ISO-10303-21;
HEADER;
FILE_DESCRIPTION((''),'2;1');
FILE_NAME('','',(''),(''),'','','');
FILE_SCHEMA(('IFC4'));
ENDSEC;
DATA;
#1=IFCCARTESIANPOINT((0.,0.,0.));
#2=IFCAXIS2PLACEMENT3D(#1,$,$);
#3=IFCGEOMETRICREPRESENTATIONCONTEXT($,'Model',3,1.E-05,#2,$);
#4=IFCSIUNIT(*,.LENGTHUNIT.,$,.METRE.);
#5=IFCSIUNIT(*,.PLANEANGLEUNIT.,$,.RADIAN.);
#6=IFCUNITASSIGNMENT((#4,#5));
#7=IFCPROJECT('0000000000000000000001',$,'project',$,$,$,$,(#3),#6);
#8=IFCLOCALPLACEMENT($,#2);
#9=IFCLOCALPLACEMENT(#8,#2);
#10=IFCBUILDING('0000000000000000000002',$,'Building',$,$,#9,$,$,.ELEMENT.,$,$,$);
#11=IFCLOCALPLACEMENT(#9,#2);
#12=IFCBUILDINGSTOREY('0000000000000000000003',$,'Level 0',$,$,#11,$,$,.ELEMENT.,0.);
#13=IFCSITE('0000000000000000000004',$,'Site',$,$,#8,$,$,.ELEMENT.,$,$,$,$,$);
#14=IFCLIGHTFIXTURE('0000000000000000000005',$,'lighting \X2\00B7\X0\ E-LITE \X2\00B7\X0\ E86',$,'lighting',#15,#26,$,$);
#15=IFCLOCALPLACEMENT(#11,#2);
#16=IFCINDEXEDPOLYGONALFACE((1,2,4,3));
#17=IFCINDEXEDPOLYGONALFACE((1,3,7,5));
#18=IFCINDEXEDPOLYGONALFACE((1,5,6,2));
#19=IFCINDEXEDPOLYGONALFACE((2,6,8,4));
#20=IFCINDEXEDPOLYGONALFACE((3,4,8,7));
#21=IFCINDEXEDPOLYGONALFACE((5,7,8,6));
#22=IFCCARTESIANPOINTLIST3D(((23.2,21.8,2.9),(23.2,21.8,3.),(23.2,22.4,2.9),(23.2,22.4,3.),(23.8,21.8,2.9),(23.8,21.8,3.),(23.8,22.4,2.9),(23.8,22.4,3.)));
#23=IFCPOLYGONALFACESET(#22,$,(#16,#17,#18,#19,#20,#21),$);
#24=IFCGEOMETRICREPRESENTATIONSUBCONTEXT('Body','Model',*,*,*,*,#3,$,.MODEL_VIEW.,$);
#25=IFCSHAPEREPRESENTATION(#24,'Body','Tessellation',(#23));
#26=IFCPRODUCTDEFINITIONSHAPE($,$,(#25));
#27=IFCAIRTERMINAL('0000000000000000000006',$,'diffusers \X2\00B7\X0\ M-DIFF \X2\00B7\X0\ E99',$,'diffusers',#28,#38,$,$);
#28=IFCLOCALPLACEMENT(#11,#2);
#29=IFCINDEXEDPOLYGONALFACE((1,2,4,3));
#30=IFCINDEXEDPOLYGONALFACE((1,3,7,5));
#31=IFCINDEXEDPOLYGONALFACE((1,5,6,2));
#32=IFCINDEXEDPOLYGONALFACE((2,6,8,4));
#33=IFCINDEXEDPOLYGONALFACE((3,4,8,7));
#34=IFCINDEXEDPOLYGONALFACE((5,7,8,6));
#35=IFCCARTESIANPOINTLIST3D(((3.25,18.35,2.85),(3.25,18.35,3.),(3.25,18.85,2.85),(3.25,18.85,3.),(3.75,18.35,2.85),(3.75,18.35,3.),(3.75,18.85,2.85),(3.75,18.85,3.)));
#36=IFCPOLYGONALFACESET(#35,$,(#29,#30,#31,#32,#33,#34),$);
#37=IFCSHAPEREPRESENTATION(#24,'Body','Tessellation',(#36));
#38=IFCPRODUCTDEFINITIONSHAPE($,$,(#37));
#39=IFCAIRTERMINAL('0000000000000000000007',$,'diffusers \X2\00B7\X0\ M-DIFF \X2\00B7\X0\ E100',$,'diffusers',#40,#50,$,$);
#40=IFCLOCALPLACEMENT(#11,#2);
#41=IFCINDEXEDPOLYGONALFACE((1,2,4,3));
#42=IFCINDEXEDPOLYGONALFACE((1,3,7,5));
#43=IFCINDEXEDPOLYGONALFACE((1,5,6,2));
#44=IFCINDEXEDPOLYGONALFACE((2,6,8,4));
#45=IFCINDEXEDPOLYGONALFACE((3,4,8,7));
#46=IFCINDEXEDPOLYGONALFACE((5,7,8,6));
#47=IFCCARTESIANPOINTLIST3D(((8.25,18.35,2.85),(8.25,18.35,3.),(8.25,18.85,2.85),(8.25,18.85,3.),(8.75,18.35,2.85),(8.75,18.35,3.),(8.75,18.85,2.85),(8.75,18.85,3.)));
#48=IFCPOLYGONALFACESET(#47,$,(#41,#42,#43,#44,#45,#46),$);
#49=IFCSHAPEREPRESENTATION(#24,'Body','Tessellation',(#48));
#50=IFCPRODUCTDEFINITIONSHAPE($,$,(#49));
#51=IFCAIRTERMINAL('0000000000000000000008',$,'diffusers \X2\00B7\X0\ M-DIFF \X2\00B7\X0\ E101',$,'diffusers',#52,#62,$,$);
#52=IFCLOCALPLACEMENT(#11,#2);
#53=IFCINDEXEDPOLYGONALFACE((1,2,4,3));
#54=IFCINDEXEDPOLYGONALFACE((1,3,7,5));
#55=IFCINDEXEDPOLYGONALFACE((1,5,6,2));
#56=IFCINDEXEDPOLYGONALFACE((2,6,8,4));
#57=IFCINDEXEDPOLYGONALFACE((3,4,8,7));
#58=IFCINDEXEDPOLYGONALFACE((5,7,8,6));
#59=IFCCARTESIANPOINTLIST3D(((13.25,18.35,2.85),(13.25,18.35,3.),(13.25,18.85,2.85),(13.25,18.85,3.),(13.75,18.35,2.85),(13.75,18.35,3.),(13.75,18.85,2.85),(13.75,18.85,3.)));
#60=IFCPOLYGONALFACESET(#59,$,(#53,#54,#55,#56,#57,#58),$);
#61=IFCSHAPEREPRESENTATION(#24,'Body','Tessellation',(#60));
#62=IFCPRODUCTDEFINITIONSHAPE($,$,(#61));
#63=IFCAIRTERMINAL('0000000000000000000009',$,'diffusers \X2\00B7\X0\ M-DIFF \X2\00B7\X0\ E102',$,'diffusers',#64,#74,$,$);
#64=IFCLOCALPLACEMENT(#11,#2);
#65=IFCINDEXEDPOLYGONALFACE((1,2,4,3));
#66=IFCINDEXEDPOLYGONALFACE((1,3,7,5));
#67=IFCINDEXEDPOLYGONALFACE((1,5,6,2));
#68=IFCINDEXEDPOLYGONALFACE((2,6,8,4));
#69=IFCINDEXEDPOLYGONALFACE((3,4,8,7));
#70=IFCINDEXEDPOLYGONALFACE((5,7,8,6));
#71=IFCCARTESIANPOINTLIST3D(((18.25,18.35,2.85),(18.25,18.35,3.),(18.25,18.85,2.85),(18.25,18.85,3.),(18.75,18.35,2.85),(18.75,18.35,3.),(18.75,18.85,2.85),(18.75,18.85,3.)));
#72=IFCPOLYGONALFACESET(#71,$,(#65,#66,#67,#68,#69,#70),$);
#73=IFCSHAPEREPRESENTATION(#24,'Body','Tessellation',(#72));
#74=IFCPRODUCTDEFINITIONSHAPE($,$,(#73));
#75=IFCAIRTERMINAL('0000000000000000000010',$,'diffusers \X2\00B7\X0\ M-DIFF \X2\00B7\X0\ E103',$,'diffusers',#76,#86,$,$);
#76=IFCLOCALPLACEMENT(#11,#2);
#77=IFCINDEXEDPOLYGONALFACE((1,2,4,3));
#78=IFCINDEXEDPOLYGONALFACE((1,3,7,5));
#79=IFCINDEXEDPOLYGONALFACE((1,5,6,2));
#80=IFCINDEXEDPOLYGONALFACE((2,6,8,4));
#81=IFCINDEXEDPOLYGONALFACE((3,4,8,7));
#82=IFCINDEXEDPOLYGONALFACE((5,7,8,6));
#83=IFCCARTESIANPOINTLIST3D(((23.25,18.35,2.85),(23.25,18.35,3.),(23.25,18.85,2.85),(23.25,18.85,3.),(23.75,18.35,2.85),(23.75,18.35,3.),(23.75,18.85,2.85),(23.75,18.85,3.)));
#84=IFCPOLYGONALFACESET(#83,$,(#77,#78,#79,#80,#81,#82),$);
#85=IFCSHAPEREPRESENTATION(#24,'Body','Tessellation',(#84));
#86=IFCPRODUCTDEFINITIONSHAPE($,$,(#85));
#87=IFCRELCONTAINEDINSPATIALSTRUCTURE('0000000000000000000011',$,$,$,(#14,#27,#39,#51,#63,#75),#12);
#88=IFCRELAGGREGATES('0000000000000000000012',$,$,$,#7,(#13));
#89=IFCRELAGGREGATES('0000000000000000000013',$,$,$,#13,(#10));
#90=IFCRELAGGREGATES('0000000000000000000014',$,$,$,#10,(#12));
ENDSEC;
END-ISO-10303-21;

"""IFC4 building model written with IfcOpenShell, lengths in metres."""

from ifc_helpers import new_model, si_unit, frame, origin, place, context, subcontext, project, spatial, polyline, outline, extrude, element, save


model = new_model("IFC4")

# Units and contexts
model_context = context("Model", 3, precision=1e-05, world=origin())
body_context = subcontext(model_context, "Body", "Model", "MODEL_VIEW")
ifc_project = project(units=[si_unit("LENGTHUNIT", "METRE"), si_unit("PLANEANGLEUNIT", "RADIAN")], contexts=[model_context])

# Site, building, storey
site_placement = place(None, origin())
site = spatial("IfcSite", under=ifc_project, at=site_placement, Name="Site", CompositionType="ELEMENT")
building_placement = place(site_placement, origin())
building = spatial("IfcBuilding", under=site, at=building_placement, Name="Building", CompositionType="ELEMENT")
storey_placement = place(building_placement, origin())
storey = spatial("IfcBuildingStorey", under=building, at=storey_placement, Name="Level 0", CompositionType="ELEMENT", Elevation=0.0)

# Light fixture
light_fixture_1_placement = place(storey_placement, frame((0.0, 0.0, 2.9)))
element("IfcLightFixture", 1, at=light_fixture_1_placement, inside=storey, Name="lighting · E-LITE · E86", ObjectType="lighting", context=body_context, shape_type="SweptSolid", body=[
    extrude(outline(polyline([(23.2, 21.8), (23.8, 21.8), (23.8, 22.4), (23.2, 22.4), (23.2, 21.8)])), origin(), (0.0, 0.0, 1.0), 0.1),
])

# Air terminals
air_terminal_1_placement = place(storey_placement, frame((0.0, 0.0, 2.85)))
element("IfcAirTerminal", 2, at=air_terminal_1_placement, inside=storey, Name="diffusers · M-DIFF · E99", ObjectType="diffusers", context=body_context, shape_type="SweptSolid", body=[
    extrude(outline(polyline([(3.25, 18.35), (3.75, 18.35), (3.75, 18.85), (3.25, 18.85), (3.25, 18.35)])), origin(), (0.0, 0.0, 1.0), 0.15),
])
air_terminal_2_placement = place(storey_placement, frame((0.0, 0.0, 2.85)))
element("IfcAirTerminal", 3, at=air_terminal_2_placement, inside=storey, Name="diffusers · M-DIFF · E100", ObjectType="diffusers", context=body_context, shape_type="SweptSolid", body=[
    extrude(outline(polyline([(8.25, 18.35), (8.75, 18.35), (8.75, 18.85), (8.25, 18.85), (8.25, 18.35)])), origin(), (0.0, 0.0, 1.0), 0.15),
])
air_terminal_3_placement = place(storey_placement, frame((0.0, 0.0, 2.85)))
element("IfcAirTerminal", 4, at=air_terminal_3_placement, inside=storey, Name="diffusers · M-DIFF · E101", ObjectType="diffusers", context=body_context, shape_type="SweptSolid", body=[
    extrude(outline(polyline([(13.25, 18.35), (13.75, 18.35), (13.75, 18.85), (13.25, 18.85), (13.25, 18.35)])), origin(), (0.0, 0.0, 1.0), 0.15),
])
air_terminal_4_placement = place(storey_placement, frame((0.0, 0.0, 2.85)))
element("IfcAirTerminal", 5, at=air_terminal_4_placement, inside=storey, Name="diffusers · M-DIFF · E102", ObjectType="diffusers", context=body_context, shape_type="SweptSolid", body=[
    extrude(outline(polyline([(18.25, 18.35), (18.75, 18.35), (18.75, 18.85), (18.25, 18.85), (18.25, 18.35)])), origin(), (0.0, 0.0, 1.0), 0.15),
])
air_terminal_5_placement = place(storey_placement, frame((0.0, 0.0, 2.85)))
element("IfcAirTerminal", 6, at=air_terminal_5_placement, inside=storey, Name="diffusers · M-DIFF · E103", ObjectType="diffusers", context=body_context, shape_type="SweptSolid", body=[
    extrude(outline(polyline([(23.25, 18.35), (23.75, 18.35), (23.75, 18.85), (23.25, 18.85), (23.25, 18.35)])), origin(), (0.0, 0.0, 1.0), 0.15),
])

save(model, "model.ifc")
